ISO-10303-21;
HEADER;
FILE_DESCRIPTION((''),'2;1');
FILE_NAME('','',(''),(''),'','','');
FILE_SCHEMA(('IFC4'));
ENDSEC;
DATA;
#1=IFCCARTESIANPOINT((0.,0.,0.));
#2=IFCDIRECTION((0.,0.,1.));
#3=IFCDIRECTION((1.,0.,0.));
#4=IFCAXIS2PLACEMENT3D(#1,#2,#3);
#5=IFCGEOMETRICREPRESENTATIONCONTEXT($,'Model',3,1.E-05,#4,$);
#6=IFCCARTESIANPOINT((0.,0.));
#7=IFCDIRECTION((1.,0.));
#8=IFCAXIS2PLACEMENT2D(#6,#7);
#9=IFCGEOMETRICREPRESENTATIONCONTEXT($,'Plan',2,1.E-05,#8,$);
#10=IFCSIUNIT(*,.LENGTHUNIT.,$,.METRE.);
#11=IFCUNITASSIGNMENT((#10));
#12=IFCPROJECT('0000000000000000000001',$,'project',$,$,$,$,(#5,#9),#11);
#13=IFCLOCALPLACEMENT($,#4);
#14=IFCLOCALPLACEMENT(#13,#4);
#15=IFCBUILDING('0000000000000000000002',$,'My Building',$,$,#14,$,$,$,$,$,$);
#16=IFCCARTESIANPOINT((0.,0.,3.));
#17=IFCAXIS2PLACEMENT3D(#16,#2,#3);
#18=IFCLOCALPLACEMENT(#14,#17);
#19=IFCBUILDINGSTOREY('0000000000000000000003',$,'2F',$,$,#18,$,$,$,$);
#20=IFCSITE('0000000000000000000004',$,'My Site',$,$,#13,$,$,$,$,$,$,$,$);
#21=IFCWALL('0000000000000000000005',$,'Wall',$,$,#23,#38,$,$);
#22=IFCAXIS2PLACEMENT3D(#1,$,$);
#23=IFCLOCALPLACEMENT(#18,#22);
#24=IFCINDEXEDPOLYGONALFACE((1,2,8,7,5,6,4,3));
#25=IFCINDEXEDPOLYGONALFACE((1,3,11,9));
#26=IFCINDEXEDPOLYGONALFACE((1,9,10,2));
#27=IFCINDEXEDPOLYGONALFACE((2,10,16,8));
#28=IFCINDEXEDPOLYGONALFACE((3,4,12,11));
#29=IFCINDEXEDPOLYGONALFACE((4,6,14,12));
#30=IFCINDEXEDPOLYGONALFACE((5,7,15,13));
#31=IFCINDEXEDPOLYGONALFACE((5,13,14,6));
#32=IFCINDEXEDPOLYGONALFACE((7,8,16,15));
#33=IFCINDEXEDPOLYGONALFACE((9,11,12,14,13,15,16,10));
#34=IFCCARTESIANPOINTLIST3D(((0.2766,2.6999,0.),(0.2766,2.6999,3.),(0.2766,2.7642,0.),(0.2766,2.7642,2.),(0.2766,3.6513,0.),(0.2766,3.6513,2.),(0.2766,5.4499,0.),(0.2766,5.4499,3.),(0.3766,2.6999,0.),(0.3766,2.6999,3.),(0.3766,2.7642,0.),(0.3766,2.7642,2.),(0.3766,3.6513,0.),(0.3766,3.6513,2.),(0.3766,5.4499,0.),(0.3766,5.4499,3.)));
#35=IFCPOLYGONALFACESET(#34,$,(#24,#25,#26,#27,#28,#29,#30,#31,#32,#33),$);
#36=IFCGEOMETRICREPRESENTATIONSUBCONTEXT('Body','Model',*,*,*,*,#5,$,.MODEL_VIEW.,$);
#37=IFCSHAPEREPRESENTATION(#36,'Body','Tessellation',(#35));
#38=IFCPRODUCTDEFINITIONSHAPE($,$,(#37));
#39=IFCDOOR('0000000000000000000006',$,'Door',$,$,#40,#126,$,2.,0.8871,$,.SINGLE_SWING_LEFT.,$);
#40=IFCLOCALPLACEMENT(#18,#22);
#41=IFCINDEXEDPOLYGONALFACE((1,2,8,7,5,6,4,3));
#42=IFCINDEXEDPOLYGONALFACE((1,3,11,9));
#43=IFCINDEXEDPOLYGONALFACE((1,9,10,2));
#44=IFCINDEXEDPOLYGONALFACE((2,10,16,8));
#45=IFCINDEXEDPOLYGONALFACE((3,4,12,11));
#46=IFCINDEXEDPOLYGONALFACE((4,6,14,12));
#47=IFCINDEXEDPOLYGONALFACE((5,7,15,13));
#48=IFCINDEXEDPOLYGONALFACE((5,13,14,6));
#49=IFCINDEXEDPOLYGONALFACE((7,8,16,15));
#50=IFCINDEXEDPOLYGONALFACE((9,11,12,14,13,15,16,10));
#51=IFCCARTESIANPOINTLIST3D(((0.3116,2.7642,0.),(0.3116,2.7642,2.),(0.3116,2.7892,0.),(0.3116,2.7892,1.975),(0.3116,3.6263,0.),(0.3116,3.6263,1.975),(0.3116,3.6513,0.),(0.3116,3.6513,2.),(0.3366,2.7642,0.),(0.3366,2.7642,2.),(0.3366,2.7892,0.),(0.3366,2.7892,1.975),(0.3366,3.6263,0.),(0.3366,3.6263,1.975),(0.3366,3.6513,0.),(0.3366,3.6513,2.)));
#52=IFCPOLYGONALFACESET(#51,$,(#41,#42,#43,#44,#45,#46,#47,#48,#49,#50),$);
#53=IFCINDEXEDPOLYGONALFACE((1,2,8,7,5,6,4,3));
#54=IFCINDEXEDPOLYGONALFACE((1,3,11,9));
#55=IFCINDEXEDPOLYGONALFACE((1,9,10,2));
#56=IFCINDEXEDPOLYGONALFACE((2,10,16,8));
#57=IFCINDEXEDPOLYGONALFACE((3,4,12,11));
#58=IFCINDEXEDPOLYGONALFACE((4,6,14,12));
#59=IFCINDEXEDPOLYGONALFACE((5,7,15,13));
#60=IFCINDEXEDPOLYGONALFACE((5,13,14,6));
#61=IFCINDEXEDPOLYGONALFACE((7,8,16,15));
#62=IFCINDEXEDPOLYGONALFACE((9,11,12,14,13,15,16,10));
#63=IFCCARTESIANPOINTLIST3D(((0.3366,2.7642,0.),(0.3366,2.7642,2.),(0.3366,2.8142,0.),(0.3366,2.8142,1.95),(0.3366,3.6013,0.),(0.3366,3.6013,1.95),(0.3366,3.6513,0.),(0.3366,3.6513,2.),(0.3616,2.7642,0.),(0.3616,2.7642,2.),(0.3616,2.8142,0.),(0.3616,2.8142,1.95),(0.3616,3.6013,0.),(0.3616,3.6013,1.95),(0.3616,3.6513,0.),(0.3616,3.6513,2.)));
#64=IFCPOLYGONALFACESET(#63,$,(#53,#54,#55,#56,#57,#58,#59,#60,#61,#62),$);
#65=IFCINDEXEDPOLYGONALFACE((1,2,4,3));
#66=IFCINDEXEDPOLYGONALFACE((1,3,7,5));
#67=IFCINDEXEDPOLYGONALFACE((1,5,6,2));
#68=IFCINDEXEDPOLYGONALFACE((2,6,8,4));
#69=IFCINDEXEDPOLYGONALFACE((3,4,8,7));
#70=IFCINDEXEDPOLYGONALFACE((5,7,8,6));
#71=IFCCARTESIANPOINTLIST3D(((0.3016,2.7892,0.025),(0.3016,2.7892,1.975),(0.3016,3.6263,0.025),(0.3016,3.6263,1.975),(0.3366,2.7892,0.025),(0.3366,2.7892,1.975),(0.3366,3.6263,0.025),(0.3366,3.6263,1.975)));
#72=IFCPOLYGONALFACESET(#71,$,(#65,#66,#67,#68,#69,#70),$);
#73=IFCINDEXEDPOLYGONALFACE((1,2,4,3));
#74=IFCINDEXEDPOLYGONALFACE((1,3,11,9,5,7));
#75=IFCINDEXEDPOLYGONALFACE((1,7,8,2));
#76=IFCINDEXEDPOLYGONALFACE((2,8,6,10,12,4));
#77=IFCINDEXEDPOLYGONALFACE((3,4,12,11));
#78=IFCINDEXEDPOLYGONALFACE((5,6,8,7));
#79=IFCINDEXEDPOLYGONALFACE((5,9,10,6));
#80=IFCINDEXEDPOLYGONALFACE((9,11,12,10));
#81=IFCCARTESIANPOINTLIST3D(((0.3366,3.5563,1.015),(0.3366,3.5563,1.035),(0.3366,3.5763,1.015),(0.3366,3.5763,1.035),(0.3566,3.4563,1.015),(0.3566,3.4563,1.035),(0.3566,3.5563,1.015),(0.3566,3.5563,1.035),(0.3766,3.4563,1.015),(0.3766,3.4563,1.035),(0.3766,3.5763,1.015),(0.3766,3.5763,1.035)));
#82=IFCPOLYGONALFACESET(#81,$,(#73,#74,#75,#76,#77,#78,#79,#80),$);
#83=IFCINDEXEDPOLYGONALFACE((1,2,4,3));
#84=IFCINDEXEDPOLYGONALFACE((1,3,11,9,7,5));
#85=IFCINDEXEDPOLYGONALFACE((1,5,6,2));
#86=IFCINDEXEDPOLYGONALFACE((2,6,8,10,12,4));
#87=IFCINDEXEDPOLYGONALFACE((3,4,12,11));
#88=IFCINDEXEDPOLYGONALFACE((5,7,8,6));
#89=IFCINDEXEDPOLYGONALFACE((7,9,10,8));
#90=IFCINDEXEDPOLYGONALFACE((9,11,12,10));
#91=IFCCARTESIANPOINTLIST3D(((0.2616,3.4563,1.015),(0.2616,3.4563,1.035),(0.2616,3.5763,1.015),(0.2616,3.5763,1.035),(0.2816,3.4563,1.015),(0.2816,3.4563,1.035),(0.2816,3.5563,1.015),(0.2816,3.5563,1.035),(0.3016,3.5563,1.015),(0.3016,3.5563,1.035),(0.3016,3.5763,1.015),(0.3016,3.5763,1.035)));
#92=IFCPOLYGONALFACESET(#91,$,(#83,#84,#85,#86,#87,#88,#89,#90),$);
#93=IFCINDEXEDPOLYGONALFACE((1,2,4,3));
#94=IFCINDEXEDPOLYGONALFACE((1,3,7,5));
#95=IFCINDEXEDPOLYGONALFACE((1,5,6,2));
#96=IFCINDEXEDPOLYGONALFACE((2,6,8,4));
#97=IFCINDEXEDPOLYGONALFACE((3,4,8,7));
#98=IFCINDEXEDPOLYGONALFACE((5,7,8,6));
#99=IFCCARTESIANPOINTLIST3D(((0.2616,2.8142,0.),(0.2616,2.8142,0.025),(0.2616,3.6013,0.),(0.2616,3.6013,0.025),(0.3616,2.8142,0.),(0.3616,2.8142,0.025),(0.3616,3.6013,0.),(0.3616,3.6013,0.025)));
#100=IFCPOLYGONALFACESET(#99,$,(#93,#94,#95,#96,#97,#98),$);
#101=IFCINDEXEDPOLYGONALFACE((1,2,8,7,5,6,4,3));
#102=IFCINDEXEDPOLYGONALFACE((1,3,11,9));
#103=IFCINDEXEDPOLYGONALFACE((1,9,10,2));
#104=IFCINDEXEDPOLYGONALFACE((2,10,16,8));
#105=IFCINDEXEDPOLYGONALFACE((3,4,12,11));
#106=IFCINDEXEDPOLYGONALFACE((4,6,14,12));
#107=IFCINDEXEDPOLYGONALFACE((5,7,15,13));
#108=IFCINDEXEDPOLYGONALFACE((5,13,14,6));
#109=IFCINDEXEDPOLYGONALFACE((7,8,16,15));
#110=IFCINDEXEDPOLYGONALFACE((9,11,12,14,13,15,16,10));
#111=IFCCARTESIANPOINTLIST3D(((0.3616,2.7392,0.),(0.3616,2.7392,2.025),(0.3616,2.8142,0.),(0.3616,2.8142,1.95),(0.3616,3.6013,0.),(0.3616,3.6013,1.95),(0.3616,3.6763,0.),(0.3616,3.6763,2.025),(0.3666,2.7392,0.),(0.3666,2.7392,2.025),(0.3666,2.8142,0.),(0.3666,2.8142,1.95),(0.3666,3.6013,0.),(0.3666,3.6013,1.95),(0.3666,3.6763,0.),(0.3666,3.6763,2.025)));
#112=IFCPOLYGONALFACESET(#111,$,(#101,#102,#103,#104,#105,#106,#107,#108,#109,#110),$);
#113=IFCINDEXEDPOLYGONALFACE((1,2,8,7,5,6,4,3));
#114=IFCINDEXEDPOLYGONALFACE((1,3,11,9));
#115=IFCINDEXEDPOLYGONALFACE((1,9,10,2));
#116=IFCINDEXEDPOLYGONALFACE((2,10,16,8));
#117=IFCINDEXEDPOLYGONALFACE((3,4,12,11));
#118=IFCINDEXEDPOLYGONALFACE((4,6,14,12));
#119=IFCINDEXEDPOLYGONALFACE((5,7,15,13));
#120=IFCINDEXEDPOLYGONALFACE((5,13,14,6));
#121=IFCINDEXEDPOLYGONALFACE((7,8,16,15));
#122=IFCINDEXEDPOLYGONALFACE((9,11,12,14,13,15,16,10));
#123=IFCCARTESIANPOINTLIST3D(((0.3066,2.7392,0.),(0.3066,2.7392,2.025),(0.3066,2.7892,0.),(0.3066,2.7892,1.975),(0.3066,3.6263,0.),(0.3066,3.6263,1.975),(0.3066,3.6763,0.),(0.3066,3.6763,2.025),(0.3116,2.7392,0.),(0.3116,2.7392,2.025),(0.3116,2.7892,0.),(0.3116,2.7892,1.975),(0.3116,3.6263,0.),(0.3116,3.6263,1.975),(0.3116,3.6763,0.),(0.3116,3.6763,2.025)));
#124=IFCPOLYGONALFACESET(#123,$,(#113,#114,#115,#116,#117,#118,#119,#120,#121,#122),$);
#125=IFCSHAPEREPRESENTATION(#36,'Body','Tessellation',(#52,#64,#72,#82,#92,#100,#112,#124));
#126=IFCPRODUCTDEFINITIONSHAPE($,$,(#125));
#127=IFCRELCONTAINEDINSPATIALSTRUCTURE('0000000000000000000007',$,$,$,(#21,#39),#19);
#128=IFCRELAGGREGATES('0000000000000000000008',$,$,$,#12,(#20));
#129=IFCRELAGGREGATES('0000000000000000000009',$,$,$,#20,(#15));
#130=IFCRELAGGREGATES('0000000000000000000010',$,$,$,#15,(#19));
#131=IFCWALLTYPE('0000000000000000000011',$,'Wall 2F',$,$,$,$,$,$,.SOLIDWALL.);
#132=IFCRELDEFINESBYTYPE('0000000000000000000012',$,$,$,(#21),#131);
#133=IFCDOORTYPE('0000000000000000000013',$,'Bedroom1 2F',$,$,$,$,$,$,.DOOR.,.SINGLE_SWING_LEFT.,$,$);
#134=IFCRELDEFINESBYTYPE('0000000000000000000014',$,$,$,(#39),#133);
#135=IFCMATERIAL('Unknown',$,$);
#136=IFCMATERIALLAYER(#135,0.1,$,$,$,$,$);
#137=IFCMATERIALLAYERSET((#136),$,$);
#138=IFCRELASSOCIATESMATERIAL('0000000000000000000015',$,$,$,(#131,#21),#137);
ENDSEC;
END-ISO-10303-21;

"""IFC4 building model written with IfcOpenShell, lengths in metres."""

from ifc_helpers import new_model, entity, si_unit, frame, origin_with_axes, origin_2d_with_axis, place, context, subcontext, project, spatial, line, indexed_curve, outline, extrude, shape, source, transform, mapped, material, layer, layer_set, layer_usage, type_object, type_shapes, element, fill, save


model = new_model("IFC4")

# Units and contexts
model_context = context("Model", 3, precision=1e-05, world=origin_with_axes())
plan_context = context("Plan", 2, precision=1e-05, world=origin_2d_with_axis())
body_context_1 = subcontext(model_context, "Body", "Model", "MODEL_VIEW")
body_context_2 = subcontext(plan_context, "Body", "Plan", "PLAN_VIEW")
ifc_project = project(units=[si_unit("LENGTHUNIT", "METRE")], contexts=[model_context, plan_context])

# Site, building, storey
site_placement = place(None, origin_with_axes())
site = spatial("IfcSite", under=ifc_project, at=site_placement, Name="My Site")
building_placement = place(site_placement, origin_with_axes())
building = spatial("IfcBuilding", under=site, at=building_placement, Name="My Building")
storey_placement = place(building_placement, frame((0.0, 0.0, 3.0), z_axis=(0.0, 0.0, 1.0), x_axis=(1.0, 0.0, 0.0)))
storey = spatial("IfcBuildingStorey", under=building, at=storey_placement, Name="2F")

# Shared definitions
ifc_material = material(Name="Unknown")

# Shared definitions
ifc_layer = layer(ifc_material, 0.1)
ifc_layer_set = layer_set([ifc_layer])
wall_type = type_object("IfcWallType", Name="Wall 2F", PredefinedType="SOLIDWALL", material=ifc_layer_set)

# Wall, opening, door
ifc_layer_usage_1 = layer_usage(ifc_layer_set, "AXIS2", "POSITIVE", 0.0)
wall_1_placement = place(storey_placement, frame((0.3766, 2.6999, 0.0), z_axis=(0.0, 0.0, 1.0), x_axis=(0.0, 1.0, 0.0)))
wall_1 = element("IfcWall", 1, at=wall_1_placement, inside=storey, type_object=wall_type, material=ifc_layer_usage_1, Name="Wall", context=body_context_1, shape_type="SweptSolid", body=[
    extrude(outline(indexed_curve([(0.0, 0.0), (0.0, 0.1), (2.75, 0.1), (2.75, 0.0)], segments=[line(1, 2, 3, 4, 1)])), origin_with_axes(), (0.0, 0.0, 1.0), 3.0),
])
shared_shape_1 = source(origin_with_axes(), body_context_1, "Body", "SweptSolid", [
    extrude(outline(indexed_curve([(0.0, 0.0), (0.8871, 0.0), (0.8871, 2.0), (0.0, 2.0)], segments=[line(1, 2, 3, 4, 1)])), frame((0.0, -0.6, 0.0), z_axis=(0.0, -1.0, 0.0), x_axis=(1.0, 0.0, 0.0)), (0.0, 0.0, -1.0), 1.2),
])
opening_1_placement = place(wall_1_placement, frame((0.0644, 0.015, 0.0), z_axis=(0.0, 0.0, 1.0), x_axis=(1.0, 0.0, 0.0)))
opening_1 = element("IfcOpeningElement", 2, at=opening_1_placement, cuts=wall_1, PredefinedType="OPENING", context=body_context_1, shape_type="MappedRepresentation", body=[
    mapped(shared_shape_1, transform((0.0, 0.0, 0.0), x_axis=(1.0, 0.0, 0.0), y_axis=(0.0, 1.0, 0.0), z_axis=(0.0, 0.0, 1.0), scale=1.0)),
])
door_type_1 = type_object("IfcDoorType", Name="Bedroom1 2F", OperationType="SINGLE_SWING_LEFT", PredefinedType="DOOR")
shared_shape_2 = source(origin_with_axes(), body_context_1, "Body", "SweptSolid", [
    extrude(outline(indexed_curve([(0.0, 0.0), (0.0, 2.0), (0.8871, 2.0), (0.8871, 0.0), (0.8621, 0.0), (0.8621, 1.975), (0.025, 1.975), (0.025, 0.0)], segments=[line(1, 2, 3, 4, 5, 6, 7, 8, 1)])), frame((0.0, 0.025, 0.0), z_axis=(0.0, -1.0, 0.0), x_axis=(1.0, 0.0, 0.0)), (0.0, 0.0, -1.0), 0.025),
    extrude(outline(indexed_curve([(0.0, 0.0), (0.0, 2.0), (0.8871, 2.0), (0.8871, 0.0), (0.8371, 0.0), (0.8371, 1.95), (0.05, 1.95), (0.05, 0.0)], segments=[line(1, 2, 3, 4, 5, 6, 7, 8, 1)])), frame((0.0, 0.0, 0.0), z_axis=(0.0, -1.0, 0.0), x_axis=(1.0, 0.0, 0.0)), (0.0, 0.0, -1.0), 0.025),
    extrude(outline(indexed_curve([(0.0, 0.0), (0.8371, 0.0), (0.8371, 0.035), (0.0, 0.035)], segments=[line(1, 2, 3, 4, 1)])), frame((0.025, 0.025, 0.025), z_axis=(0.0, 0.0, 1.0), x_axis=(1.0, 0.0, 0.0)), (0.0, 0.0, 1.0), 1.95),
    extrude(outline(indexed_curve([(0.0, 0.0), (0.0, -0.04), (-0.12, -0.04), (-0.12, -0.02), (-0.02, -0.02), (-0.02, 0.0)], segments=[line(1, 2, 3, 4, 5, 6, 1)])), frame((0.8121, 0.025, 1.015), z_axis=(0.0, 0.0, 1.0), x_axis=(1.0, 0.0, 0.0)), (0.0, 0.0, 1.0), 0.02),
    extrude(outline(indexed_curve([(0.0, 0.0), (0.0, 0.04), (-0.12, 0.04), (-0.12, 0.02), (-0.02, 0.02), (-0.02, 0.0)], segments=[line(1, 2, 3, 4, 5, 6, 1)])), frame((0.8121, 0.06, 1.015), z_axis=(0.0, 0.0, 1.0), x_axis=(1.0, 0.0, 0.0)), (0.0, 0.0, 1.0), 0.02),
    extrude(outline(indexed_curve([(0.0, 0.0), (0.7871, 0.0), (0.7871, 0.1), (0.0, 0.1)], segments=[line(1, 2, 3, 4, 1)])), frame((0.05, 0.0, 0.0), z_axis=(0.0, 0.0, 1.0), x_axis=(1.0, 0.0, 0.0)), (0.0, 0.0, 1.0), 0.025),
    extrude(outline(indexed_curve([(0.0, 0.0), (0.0, 2.025), (0.9371, 2.025), (0.9371, 0.0), (0.8621, 0.0), (0.8621, 1.95), (0.075, 1.95), (0.075, 0.0)], segments=[line(1, 2, 3, 4, 5, 6, 7, 8, 1)])), frame((-0.025, -0.005, 0.0), z_axis=(0.0, -1.0, 0.0), x_axis=(1.0, 0.0, 0.0)), (0.0, 0.0, -1.0), 0.005),
    extrude(outline(indexed_curve([(0.0, 0.0), (0.0, 2.025), (0.9371, 2.025), (0.9371, 0.0), (0.8871, 0.0), (0.8871, 1.975), (0.05, 1.975), (0.05, 0.0)], segments=[line(1, 2, 3, 4, 5, 6, 7, 8, 1)])), frame((-0.025, 0.05, 0.0), z_axis=(0.0, -1.0, 0.0), x_axis=(1.0, 0.0, 0.0)), (0.0, 0.0, -1.0), 0.005),
])
shared_shape_3 = source(origin_with_axes(), body_context_2, "Body", "Curve2D", [
    entity("IfcIndexedPolyCurve", entity("IfcCartesianPointList2D", [[0.0, 0.0], [0.0, 0.05], [0.025, 0.05], [0.025, 0.025], [0.05, 0.025], [0.05, 0.0]]), [entity("IfcLineIndex", [1, 2, 3, 4, 5, 6, 1])]),
    entity("IfcIndexedPolyCurve", entity("IfcCartesianPointList2D", [[0.8871, 0.0], [0.8871, 0.05], [0.8621, 0.05], [0.8621, 0.025], [0.8371, 0.025], [0.8371, 0.0]]), [entity("IfcLineIndex", [1, 2, 3, 4, 5, 6, 1])]),
    entity("IfcTrimmedCurve", entity("IfcEllipse", entity("IfcAxis2Placement2D", entity("IfcCartesianPoint", [0.06, 0.05]), entity("IfcDirection", [1.0, 0.0])), 0.8021, 0.8371), [entity("IfcCartesianPoint", [0.8621, 0.05])], [entity("IfcCartesianPoint", [0.06, 0.8871])], True, "CARTESIAN"),
    entity("IfcIndexedPolyCurve", entity("IfcCartesianPointList2D", [[0.025, 0.05], [0.06, 0.05], [0.06, 0.8871], [0.025, 0.8871]]), [entity("IfcLineIndex", [1, 2, 3, 4, 1])]),
])
type_shapes(door_type_1, [shared_shape_2, shared_shape_3])
door_1_placement = place(opening_1_placement, frame((0.0, 0.0, 0.0), z_axis=(0.0, 0.0, 1.0), x_axis=(1.0, 0.0, 0.0)))
door_1 = element("IfcDoor", 3, at=door_1_placement, inside=storey, type_object=door_type_1, Name="Door", OperationType="SINGLE_SWING_LEFT", OverallHeight=2.0, OverallWidth=0.8871, shapes=[
    shape(body_context_1, "Body", "MappedRepresentation", [mapped(shared_shape_2, transform((0.0, 0.0, 0.0), x_axis=(1.0, 0.0, 0.0), y_axis=(0.0, 1.0, 0.0), z_axis=(0.0, 0.0, 1.0), scale=1.0))]),
    shape(body_context_2, "Body", "MappedRepresentation", [mapped(shared_shape_3, transform((0.0, 0.0, 0.0), x_axis=(1.0, 0.0, 0.0), y_axis=(0.0, 1.0, 0.0), z_axis=(0.0, 0.0, 1.0), scale=1.0))]),
])
fill(opening_1, door_1)

save(model, "model.ifc")
